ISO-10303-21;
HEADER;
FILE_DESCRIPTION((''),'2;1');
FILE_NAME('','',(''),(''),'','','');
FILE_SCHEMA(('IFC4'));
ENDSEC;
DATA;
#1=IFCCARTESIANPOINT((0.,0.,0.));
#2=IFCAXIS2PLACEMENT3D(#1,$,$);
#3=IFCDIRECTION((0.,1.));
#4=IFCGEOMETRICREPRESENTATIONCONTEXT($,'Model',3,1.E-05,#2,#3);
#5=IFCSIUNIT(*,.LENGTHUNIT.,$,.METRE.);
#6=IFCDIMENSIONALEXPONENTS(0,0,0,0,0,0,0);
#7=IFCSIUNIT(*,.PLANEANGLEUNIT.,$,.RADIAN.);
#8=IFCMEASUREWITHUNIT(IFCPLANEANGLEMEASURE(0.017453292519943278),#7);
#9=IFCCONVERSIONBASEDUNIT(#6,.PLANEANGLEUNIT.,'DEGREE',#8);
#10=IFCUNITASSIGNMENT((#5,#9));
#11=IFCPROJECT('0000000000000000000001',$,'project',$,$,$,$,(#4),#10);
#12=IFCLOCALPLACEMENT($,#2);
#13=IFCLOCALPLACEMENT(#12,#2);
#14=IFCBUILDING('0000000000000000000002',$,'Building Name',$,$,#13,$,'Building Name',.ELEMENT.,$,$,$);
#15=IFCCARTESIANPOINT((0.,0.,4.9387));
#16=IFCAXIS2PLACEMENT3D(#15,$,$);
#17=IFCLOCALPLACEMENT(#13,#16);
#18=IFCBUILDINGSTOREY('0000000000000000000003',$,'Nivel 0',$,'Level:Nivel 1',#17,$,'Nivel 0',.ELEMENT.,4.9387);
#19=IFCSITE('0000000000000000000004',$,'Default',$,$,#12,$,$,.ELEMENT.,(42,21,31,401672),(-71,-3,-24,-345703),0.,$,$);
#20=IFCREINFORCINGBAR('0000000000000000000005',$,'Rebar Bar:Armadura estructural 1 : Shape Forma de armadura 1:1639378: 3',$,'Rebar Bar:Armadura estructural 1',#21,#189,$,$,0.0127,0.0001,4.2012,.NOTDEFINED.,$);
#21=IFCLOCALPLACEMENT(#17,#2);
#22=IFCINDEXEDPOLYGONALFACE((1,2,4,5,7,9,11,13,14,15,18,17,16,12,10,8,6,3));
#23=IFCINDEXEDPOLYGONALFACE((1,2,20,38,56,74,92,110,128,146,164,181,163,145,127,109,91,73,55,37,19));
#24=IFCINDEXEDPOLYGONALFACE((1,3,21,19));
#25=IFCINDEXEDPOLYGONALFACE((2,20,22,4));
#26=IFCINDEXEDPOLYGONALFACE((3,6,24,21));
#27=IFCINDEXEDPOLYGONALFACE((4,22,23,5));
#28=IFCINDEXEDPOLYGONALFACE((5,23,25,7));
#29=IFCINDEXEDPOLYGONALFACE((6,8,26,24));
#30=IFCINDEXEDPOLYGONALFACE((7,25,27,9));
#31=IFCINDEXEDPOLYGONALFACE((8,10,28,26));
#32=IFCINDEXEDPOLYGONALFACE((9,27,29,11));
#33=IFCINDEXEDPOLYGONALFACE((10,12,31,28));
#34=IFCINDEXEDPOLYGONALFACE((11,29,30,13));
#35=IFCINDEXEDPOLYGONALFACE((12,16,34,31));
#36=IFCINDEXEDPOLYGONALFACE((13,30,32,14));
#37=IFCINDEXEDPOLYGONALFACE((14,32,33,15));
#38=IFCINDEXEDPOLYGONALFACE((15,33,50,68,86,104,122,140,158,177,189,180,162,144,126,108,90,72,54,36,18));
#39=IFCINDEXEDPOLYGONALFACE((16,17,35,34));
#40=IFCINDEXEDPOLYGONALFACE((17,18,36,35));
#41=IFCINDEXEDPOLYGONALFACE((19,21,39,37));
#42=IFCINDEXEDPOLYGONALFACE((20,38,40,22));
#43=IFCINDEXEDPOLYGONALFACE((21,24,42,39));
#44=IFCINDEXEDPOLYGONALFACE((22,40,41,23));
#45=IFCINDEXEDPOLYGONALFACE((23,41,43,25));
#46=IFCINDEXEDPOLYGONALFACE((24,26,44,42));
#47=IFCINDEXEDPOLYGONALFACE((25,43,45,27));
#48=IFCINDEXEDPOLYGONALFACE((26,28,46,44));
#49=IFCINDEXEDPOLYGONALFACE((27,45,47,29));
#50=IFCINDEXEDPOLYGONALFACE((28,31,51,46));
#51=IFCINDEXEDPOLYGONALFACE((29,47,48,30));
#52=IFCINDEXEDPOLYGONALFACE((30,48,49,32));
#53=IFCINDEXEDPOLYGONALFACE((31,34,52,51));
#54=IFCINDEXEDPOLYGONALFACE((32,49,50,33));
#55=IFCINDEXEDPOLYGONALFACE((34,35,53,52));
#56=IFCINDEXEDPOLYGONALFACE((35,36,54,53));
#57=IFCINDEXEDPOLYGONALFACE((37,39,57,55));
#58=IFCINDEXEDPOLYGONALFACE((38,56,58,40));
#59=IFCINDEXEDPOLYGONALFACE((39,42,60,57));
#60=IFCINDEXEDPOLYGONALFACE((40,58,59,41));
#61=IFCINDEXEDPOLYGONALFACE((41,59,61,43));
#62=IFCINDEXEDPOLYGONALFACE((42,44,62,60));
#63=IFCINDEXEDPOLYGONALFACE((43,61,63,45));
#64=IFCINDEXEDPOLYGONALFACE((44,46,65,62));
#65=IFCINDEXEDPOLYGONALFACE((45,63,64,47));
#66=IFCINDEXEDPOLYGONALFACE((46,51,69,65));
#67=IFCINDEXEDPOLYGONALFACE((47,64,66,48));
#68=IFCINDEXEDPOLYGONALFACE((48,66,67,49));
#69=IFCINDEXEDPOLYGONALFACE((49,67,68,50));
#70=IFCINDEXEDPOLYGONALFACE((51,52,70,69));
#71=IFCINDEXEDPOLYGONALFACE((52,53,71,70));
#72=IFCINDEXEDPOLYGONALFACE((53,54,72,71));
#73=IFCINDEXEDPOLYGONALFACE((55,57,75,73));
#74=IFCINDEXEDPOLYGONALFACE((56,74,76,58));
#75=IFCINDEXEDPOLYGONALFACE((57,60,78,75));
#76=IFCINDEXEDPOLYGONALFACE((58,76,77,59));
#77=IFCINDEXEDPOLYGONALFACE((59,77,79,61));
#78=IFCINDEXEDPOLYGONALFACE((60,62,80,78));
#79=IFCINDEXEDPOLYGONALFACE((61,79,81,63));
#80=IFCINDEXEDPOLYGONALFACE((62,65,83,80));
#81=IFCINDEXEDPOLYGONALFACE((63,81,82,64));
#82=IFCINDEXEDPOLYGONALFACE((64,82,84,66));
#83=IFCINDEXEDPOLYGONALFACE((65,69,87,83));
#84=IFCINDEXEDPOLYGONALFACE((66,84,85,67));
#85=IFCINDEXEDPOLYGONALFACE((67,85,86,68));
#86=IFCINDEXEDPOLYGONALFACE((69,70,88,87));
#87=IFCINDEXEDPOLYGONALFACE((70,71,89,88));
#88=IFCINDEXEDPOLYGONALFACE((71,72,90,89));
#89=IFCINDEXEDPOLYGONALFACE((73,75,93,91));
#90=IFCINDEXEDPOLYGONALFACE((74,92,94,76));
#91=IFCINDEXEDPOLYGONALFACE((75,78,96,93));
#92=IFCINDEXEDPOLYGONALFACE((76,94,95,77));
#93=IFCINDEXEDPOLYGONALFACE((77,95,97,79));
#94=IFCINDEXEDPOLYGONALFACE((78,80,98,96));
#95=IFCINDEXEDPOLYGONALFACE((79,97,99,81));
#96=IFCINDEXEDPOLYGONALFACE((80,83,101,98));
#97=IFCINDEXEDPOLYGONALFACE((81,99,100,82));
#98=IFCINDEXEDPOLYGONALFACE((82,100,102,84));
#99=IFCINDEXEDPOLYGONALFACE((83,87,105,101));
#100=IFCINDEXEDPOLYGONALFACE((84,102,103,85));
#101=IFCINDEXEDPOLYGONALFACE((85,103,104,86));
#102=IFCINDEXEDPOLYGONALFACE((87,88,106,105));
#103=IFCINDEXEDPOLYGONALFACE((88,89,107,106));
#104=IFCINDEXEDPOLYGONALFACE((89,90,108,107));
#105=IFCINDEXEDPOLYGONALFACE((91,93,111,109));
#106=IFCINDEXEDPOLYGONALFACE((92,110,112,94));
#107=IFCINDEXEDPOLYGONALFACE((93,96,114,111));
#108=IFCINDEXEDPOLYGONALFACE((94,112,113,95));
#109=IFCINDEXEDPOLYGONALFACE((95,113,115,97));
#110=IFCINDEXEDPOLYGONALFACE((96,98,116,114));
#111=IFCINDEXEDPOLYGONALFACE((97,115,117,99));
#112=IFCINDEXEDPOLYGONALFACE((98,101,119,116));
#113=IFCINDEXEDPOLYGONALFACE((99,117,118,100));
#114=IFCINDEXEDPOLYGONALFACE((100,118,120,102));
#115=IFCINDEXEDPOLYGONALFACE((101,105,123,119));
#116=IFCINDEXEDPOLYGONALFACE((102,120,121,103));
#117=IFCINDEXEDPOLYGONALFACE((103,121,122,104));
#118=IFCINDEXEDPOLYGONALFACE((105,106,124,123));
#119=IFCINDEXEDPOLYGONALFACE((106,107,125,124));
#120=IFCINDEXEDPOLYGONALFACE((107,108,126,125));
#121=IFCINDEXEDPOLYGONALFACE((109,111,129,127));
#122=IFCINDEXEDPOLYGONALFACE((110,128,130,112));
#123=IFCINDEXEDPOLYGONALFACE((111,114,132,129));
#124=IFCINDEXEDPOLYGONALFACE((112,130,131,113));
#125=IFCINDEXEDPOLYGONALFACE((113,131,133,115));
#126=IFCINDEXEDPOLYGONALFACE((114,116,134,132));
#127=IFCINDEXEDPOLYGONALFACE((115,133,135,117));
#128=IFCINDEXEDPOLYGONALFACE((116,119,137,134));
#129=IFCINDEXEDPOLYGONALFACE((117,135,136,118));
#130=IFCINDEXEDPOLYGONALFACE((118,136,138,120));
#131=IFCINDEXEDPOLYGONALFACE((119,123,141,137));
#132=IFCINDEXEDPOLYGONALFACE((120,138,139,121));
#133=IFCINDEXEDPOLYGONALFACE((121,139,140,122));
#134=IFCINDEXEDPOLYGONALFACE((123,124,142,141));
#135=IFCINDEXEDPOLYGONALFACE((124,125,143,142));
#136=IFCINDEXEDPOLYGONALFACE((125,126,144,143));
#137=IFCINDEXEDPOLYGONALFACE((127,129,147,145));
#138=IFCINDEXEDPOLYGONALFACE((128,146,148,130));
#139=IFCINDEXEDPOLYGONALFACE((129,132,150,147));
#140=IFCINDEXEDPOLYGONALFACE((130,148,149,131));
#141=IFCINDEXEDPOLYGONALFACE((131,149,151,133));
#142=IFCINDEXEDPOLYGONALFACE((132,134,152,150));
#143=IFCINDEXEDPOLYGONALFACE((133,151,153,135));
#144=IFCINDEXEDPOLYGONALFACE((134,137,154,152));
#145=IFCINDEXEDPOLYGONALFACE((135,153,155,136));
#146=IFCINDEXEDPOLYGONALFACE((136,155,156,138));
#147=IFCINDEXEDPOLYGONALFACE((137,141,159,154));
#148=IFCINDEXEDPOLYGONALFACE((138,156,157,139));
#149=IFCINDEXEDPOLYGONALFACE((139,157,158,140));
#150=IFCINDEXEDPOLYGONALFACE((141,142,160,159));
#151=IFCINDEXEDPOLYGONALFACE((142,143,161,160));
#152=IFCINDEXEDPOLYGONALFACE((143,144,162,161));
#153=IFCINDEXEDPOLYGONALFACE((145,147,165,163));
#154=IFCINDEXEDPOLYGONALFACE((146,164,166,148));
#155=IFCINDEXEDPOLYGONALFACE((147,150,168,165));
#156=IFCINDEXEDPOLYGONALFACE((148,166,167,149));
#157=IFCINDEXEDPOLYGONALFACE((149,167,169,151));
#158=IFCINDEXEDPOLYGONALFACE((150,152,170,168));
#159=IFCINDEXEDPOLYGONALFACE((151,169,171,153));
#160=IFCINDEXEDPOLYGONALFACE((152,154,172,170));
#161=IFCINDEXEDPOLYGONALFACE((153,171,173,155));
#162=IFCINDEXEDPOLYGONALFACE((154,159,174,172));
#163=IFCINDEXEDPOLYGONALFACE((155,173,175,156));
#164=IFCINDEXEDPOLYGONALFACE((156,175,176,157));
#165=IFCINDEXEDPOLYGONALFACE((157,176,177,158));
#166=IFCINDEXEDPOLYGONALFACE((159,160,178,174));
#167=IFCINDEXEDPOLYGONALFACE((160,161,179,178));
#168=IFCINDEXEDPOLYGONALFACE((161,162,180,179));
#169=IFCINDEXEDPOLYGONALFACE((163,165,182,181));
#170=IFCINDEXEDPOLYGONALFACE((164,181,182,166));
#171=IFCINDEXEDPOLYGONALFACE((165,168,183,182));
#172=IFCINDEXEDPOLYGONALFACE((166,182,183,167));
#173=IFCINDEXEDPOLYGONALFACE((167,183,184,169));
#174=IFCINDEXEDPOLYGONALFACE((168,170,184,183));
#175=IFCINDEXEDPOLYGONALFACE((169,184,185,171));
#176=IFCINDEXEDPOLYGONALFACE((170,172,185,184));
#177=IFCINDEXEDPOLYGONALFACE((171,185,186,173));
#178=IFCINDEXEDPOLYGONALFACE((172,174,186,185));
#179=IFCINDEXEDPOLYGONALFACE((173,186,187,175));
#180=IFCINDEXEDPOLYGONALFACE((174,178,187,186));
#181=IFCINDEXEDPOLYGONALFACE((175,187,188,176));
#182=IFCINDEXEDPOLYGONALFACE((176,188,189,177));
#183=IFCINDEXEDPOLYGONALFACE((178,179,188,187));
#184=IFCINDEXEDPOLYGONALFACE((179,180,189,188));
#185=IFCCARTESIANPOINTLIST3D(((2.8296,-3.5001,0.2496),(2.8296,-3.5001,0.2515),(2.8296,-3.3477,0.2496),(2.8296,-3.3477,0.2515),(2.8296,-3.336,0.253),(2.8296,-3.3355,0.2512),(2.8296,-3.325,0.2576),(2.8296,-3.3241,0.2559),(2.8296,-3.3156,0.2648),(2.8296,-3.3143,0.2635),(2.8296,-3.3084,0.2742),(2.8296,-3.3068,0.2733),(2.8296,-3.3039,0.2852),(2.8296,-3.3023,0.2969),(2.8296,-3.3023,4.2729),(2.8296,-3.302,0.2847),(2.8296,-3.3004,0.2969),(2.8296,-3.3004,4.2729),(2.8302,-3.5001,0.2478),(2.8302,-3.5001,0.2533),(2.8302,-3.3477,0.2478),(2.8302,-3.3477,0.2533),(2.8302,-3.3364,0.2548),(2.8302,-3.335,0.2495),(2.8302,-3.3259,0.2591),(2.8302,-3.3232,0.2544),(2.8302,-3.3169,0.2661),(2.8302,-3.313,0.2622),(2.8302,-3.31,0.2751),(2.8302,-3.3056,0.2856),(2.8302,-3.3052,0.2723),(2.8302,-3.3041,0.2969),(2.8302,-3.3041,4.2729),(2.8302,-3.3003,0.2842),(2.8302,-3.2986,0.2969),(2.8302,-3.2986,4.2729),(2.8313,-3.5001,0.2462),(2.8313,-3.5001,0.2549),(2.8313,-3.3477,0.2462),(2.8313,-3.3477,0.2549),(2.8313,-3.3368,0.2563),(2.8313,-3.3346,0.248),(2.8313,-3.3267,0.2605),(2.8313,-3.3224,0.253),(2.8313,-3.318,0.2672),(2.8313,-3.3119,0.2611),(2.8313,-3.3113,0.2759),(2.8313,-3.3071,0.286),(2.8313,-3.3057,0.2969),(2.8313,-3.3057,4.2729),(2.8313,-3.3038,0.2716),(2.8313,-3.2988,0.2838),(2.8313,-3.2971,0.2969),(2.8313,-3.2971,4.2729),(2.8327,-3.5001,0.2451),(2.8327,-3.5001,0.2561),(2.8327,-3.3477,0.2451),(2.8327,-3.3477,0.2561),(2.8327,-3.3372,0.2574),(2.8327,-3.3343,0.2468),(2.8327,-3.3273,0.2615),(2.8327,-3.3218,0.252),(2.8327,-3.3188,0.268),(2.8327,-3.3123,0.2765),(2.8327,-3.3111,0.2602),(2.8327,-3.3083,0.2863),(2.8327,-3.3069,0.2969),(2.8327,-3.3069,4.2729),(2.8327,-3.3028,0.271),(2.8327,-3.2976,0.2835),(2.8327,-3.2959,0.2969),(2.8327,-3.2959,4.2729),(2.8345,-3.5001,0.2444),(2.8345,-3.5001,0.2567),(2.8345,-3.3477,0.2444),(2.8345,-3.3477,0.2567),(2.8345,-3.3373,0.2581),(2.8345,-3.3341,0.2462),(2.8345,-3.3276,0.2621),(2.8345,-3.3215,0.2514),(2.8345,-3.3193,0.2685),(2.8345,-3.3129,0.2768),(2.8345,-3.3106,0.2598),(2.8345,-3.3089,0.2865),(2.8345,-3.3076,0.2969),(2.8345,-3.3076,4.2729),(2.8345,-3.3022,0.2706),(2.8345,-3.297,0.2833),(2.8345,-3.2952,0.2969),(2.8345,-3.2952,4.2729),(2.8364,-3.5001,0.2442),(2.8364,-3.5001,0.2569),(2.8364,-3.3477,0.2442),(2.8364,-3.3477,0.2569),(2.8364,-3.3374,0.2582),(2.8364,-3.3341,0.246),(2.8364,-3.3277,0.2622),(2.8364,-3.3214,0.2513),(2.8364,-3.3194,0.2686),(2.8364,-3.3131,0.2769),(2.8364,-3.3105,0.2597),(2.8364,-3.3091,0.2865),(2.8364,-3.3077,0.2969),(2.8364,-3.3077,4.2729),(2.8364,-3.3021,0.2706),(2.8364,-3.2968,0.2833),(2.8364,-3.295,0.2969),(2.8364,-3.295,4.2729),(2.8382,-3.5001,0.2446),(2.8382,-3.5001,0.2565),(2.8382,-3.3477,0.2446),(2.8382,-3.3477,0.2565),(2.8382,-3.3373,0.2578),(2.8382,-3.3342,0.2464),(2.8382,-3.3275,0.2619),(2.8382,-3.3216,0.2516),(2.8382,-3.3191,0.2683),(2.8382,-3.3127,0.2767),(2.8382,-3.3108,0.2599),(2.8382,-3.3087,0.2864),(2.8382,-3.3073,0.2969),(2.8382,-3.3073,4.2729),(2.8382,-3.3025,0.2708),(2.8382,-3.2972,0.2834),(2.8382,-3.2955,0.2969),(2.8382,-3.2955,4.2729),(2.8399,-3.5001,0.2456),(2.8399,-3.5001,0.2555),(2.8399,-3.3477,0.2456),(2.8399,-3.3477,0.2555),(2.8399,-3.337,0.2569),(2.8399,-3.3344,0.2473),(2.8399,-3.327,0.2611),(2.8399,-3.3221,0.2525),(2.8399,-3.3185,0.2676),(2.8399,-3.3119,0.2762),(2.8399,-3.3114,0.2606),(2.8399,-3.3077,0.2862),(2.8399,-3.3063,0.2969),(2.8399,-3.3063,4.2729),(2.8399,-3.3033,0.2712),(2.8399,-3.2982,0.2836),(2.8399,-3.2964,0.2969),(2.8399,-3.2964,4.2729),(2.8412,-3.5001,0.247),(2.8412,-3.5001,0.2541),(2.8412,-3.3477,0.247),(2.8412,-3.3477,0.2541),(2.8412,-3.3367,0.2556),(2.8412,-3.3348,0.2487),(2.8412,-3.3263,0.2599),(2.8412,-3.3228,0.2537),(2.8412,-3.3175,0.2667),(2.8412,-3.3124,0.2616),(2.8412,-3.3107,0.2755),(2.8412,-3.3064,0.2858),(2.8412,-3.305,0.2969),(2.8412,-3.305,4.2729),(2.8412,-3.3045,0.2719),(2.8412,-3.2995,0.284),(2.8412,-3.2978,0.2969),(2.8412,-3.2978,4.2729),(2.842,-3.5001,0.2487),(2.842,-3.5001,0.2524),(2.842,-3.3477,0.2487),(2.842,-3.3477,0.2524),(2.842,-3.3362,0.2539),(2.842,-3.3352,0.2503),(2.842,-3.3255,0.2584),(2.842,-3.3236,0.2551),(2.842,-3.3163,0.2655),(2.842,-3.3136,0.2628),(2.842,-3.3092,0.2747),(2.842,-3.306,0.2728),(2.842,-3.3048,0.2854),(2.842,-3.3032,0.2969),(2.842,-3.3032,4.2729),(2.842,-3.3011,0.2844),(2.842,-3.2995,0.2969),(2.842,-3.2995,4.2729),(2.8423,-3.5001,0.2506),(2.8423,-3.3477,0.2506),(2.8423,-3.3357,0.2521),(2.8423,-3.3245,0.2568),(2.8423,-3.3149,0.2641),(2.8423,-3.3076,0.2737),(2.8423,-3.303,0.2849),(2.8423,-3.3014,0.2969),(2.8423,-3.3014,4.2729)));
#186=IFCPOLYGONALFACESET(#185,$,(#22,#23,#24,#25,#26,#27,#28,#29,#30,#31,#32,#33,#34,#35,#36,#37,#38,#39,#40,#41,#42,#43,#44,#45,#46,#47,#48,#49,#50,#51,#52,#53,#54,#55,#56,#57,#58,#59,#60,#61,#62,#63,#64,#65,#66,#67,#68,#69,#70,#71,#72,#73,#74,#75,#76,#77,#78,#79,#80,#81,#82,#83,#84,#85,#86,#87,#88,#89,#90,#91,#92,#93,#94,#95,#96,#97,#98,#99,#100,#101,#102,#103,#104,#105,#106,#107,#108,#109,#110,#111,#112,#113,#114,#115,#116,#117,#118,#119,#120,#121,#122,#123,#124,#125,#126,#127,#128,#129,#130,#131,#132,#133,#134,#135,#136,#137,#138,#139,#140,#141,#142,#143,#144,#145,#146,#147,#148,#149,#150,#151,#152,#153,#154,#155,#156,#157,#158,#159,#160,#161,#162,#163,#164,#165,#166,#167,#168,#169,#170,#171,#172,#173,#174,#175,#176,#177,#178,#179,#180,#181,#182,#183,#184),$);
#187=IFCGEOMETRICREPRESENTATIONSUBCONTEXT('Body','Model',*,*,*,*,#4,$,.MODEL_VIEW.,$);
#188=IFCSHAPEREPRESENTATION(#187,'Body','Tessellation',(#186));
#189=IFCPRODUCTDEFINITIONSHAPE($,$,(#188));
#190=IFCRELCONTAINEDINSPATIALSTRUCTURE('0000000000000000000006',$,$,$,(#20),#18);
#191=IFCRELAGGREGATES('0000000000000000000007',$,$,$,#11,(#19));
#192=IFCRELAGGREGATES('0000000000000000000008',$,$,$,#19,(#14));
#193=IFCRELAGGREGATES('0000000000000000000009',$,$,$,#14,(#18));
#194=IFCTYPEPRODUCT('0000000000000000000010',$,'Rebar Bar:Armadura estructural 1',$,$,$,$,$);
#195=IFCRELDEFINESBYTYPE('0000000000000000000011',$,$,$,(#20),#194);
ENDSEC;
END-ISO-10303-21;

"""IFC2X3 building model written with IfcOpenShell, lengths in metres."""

from ifc_helpers import new_model, entity, si_unit, converted_unit, direction, frame, origin, place, context, subcontext, project, spatial, type_object, element, save


model = new_model("IFC2X3")

# Units and contexts
model_context = context("Model", 3, precision=1e-05, world=origin(), true_north=direction((0.0, 1.0)))
body_context = subcontext(model_context, "Body", "Model", "MODEL_VIEW")
ifc_project = project(units=[si_unit("LENGTHUNIT", "METRE"), converted_unit("PLANEANGLEUNIT", "DEGREE", entity("IfcPlaneAngleMeasure", 0.017453292519943278), si_unit("PLANEANGLEUNIT", "RADIAN"), dimensions=[0, 0, 0, 0, 0, 0, 0])], contexts=[model_context])

# Site, building, storey
site_placement = place(None, origin())
site = spatial("IfcSite", under=ifc_project, at=site_placement, Name="Default", CompositionType="ELEMENT", RefLatitude=(42, 21, 31, 401672), RefLongitude=(-71, -3, -24, -345703), RefElevation=0.0)
building_placement = place(site_placement, origin())
building = spatial("IfcBuilding", under=site, at=building_placement, Name="Building Name", LongName="Building Name", CompositionType="ELEMENT")
storey_placement = place(building_placement, frame((0.0, 0.0, 4.9387)))
storey = spatial("IfcBuildingStorey", under=building, at=storey_placement, Name="Nivel 0", ObjectType="Level:Nivel 1", LongName="Nivel 0", CompositionType="ELEMENT", Elevation=4.9387)

# Reinforcing bar
type_product = type_object("IfcTypeProduct", Name="Rebar Bar:Armadura estructural 1")
reinforcing_bar_1_placement = place(storey_placement, origin())
element("IfcReinforcingBar", 1, at=reinforcing_bar_1_placement, inside=storey, type_object=type_product, Name="Rebar Bar:Armadura estructural 1 : Shape Forma de armadura 1:1639378: 3", ObjectType="Rebar Bar:Armadura estructural 1", BarLength=4.2012, BarRole="NOTDEFINED", CrossSectionArea=0.0001, NominalDiameter=0.0127, context=body_context, shape_type="AdvancedSweptSolid", body=[
    entity("IfcSweptDiskSolid", entity("IfcCompositeCurve", [entity("IfcCompositeCurveSegment", "CONTINUOUS", True, entity("IfcPolyline", [entity("IfcCartesianPoint", [2.8359, -3.5001, 0.2506]), entity("IfcCartesianPoint", [2.8359, -3.3477, 0.2506])])), entity("IfcCompositeCurveSegment", "CONTINUOUS", True, entity("IfcTrimmedCurve", entity("IfcCircle", entity("IfcAxis2Placement3D", entity("IfcCartesianPoint", [2.8359, -3.3477, 0.2969]), entity("IfcDirection", [1.0, 0.0, 0.0]), entity("IfcDirection", [0.0, 1.0, 0.0])), 0.0464), [entity("IfcParameterValue", 270.0)], [entity("IfcParameterValue", 360.0)], True, "PARAMETER")), entity("IfcCompositeCurveSegment", "CONTINUOUS", True, entity("IfcPolyline", [entity("IfcCartesianPoint", [2.8359, -3.3014, 0.2969]), entity("IfcCartesianPoint", [2.8359, -3.3014, 4.2729])]))], False), 0.0063, None, 0.0, 92.0),
])

save(model, "model.ifc")
